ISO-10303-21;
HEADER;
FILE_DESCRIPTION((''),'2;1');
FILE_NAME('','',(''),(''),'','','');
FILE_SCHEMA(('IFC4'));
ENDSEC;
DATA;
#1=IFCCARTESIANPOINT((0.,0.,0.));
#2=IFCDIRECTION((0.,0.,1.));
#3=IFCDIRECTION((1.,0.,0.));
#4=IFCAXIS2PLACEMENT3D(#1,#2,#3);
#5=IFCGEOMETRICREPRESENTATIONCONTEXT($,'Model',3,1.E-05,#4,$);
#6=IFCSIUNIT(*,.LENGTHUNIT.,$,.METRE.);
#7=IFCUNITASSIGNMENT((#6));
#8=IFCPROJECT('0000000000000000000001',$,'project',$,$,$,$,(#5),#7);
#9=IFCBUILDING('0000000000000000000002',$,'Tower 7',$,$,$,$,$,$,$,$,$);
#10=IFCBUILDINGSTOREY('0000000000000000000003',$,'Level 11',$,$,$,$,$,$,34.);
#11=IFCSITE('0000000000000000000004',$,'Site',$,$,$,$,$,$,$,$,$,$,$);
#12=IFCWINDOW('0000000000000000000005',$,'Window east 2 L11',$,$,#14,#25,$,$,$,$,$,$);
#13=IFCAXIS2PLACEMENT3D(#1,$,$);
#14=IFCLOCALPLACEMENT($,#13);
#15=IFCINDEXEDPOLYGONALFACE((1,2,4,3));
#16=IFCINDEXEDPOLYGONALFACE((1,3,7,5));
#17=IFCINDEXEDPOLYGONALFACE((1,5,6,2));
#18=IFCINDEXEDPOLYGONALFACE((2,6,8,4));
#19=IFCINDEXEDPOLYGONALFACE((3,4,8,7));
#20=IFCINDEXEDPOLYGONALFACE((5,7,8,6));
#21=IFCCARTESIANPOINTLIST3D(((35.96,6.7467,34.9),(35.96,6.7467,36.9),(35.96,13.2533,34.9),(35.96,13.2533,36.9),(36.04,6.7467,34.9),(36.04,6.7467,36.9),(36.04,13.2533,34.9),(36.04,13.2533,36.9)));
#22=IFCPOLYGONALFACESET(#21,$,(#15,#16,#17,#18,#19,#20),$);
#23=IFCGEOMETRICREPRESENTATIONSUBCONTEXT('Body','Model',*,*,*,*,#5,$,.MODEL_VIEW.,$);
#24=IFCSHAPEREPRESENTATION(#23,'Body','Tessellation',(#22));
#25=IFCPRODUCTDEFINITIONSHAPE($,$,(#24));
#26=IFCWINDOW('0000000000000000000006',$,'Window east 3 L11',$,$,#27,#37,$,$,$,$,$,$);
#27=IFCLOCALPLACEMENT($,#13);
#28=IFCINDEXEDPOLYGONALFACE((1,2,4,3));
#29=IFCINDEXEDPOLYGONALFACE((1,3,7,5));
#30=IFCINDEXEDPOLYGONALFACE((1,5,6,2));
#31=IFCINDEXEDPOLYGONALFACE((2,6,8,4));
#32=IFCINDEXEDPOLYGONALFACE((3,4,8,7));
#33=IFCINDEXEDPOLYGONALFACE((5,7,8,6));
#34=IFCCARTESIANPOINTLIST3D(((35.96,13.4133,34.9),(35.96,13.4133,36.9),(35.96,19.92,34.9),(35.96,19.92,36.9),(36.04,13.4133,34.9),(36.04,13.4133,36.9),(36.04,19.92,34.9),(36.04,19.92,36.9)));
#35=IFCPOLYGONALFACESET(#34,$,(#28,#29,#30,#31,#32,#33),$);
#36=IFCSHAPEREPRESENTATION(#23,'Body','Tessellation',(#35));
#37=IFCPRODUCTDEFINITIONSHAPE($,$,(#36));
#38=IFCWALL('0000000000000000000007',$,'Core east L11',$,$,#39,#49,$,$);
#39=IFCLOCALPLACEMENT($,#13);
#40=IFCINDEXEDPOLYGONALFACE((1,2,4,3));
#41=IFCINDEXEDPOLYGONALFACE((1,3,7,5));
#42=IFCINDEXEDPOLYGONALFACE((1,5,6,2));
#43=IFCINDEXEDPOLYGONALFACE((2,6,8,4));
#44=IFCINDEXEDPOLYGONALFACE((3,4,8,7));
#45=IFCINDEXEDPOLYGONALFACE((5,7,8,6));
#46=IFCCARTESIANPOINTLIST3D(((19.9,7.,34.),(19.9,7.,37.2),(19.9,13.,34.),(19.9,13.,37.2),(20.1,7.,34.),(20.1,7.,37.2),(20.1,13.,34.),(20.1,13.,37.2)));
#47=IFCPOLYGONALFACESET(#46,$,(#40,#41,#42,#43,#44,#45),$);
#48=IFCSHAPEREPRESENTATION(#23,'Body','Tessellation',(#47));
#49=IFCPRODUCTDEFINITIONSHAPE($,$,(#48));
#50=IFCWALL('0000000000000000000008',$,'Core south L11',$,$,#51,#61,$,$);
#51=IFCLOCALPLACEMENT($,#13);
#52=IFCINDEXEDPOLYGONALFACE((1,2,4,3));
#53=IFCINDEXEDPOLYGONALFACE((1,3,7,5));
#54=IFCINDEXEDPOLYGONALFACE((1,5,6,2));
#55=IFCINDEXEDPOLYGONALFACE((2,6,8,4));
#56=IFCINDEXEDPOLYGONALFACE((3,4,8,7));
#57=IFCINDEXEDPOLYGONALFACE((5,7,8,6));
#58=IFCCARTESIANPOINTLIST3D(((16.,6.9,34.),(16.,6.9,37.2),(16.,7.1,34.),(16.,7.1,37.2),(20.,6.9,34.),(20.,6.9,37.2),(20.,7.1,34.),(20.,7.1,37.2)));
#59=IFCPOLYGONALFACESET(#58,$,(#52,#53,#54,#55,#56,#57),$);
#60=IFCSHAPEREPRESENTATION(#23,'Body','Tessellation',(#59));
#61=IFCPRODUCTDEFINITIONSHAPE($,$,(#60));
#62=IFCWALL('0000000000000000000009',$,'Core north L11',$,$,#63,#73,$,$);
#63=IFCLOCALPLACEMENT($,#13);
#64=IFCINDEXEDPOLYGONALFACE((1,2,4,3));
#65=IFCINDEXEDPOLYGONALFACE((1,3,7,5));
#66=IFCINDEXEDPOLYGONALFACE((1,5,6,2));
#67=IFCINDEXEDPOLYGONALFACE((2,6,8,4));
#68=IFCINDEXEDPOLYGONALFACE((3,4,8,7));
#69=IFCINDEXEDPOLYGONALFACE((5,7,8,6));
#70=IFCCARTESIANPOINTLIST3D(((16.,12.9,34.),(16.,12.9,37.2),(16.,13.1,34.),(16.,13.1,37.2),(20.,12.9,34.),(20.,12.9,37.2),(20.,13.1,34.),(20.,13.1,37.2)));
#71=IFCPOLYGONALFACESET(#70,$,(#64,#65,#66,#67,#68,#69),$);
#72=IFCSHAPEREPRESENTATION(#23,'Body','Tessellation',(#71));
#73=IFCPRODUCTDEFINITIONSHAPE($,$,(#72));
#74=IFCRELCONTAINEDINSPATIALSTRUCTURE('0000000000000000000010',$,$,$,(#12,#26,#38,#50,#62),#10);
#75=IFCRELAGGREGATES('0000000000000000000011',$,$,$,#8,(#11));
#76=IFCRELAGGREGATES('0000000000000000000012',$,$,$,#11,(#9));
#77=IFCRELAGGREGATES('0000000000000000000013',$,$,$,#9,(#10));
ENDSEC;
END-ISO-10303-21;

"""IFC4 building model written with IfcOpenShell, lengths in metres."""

from ifc_helpers import new_model, si_unit, frame, origin, origin_with_axes, origin_2d, place, context, subcontext, project, spatial, rectangle, extrude, element, save


model = new_model("IFC4")

# Units and contexts
model_context = context("Model", 3, precision=1e-05, world=origin_with_axes())
body_context = subcontext(model_context, "Body", "Model", "MODEL_VIEW")
ifc_project = project(units=[si_unit("LENGTHUNIT", "METRE")], contexts=[model_context])

# Site, building, storey
site = spatial("IfcSite", under=ifc_project, Name="Site")
building = spatial("IfcBuilding", under=site, Name="Tower 7")
storey = spatial("IfcBuildingStorey", under=building, Name="Level 11", Elevation=34.0)

# Windows
for number, where, z_axis, x_axis, name in (
    (1, (36.0, 10.0, 34.9), (0.0, 0.0, 1.0), (1.0, 0.0, 0.0), "Window east 2 L11"),
):
    element("IfcWindow", number, at=place(None, frame(where, z_axis=z_axis, x_axis=x_axis)), inside=storey, Name=name, context=body_context, shape_type="SweptSolid", body=[
        extrude(rectangle(XDim=0.08, YDim=6.5067, at=origin_2d()), origin(), (0.0, 0.0, 1.0), 2.0),
    ])
window_placement = place(None, frame((36.0, 16.6667, 34.9), z_axis=(0.0, 0.0, 1.0), x_axis=(1.0, 0.0, 0.0)))
element("IfcWindow", 2, at=window_placement, inside=storey, Name="Window east 3 L11", context=body_context, shape_type="SweptSolid", body=[
    extrude(rectangle(XDim=0.08, YDim=6.5067, at=origin_2d()), origin(), (0.0, 0.0, 1.0), 2.0),
])

# Walls
wall_1_placement = place(None, frame((20.0, 10.0, 34.0), z_axis=(0.0, 0.0, 1.0), x_axis=(1.0, 0.0, 0.0)))
element("IfcWall", 3, at=wall_1_placement, inside=storey, Name="Core east L11", context=body_context, shape_type="SweptSolid", body=[
    extrude(rectangle(XDim=0.2, YDim=6.0, at=origin_2d()), origin(), (0.0, 0.0, 1.0), 3.2),
])
for number, where, z_axis, x_axis, name in (
    (4, (18.0, 7.0, 34.0), (0.0, 0.0, 1.0), (1.0, 0.0, 0.0), "Core south L11"),
    (5, (18.0, 13.0, 34.0), (0.0, 0.0, 1.0), (1.0, 0.0, 0.0), "Core north L11"),
):
    element("IfcWall", number, at=place(None, frame(where, z_axis=z_axis, x_axis=x_axis)), inside=storey, Name=name, context=body_context, shape_type="SweptSolid", body=[
        extrude(rectangle(XDim=4.0, YDim=0.2, at=origin_2d()), origin(), (0.0, 0.0, 1.0), 3.2),
    ])

save(model, "model.ifc")
